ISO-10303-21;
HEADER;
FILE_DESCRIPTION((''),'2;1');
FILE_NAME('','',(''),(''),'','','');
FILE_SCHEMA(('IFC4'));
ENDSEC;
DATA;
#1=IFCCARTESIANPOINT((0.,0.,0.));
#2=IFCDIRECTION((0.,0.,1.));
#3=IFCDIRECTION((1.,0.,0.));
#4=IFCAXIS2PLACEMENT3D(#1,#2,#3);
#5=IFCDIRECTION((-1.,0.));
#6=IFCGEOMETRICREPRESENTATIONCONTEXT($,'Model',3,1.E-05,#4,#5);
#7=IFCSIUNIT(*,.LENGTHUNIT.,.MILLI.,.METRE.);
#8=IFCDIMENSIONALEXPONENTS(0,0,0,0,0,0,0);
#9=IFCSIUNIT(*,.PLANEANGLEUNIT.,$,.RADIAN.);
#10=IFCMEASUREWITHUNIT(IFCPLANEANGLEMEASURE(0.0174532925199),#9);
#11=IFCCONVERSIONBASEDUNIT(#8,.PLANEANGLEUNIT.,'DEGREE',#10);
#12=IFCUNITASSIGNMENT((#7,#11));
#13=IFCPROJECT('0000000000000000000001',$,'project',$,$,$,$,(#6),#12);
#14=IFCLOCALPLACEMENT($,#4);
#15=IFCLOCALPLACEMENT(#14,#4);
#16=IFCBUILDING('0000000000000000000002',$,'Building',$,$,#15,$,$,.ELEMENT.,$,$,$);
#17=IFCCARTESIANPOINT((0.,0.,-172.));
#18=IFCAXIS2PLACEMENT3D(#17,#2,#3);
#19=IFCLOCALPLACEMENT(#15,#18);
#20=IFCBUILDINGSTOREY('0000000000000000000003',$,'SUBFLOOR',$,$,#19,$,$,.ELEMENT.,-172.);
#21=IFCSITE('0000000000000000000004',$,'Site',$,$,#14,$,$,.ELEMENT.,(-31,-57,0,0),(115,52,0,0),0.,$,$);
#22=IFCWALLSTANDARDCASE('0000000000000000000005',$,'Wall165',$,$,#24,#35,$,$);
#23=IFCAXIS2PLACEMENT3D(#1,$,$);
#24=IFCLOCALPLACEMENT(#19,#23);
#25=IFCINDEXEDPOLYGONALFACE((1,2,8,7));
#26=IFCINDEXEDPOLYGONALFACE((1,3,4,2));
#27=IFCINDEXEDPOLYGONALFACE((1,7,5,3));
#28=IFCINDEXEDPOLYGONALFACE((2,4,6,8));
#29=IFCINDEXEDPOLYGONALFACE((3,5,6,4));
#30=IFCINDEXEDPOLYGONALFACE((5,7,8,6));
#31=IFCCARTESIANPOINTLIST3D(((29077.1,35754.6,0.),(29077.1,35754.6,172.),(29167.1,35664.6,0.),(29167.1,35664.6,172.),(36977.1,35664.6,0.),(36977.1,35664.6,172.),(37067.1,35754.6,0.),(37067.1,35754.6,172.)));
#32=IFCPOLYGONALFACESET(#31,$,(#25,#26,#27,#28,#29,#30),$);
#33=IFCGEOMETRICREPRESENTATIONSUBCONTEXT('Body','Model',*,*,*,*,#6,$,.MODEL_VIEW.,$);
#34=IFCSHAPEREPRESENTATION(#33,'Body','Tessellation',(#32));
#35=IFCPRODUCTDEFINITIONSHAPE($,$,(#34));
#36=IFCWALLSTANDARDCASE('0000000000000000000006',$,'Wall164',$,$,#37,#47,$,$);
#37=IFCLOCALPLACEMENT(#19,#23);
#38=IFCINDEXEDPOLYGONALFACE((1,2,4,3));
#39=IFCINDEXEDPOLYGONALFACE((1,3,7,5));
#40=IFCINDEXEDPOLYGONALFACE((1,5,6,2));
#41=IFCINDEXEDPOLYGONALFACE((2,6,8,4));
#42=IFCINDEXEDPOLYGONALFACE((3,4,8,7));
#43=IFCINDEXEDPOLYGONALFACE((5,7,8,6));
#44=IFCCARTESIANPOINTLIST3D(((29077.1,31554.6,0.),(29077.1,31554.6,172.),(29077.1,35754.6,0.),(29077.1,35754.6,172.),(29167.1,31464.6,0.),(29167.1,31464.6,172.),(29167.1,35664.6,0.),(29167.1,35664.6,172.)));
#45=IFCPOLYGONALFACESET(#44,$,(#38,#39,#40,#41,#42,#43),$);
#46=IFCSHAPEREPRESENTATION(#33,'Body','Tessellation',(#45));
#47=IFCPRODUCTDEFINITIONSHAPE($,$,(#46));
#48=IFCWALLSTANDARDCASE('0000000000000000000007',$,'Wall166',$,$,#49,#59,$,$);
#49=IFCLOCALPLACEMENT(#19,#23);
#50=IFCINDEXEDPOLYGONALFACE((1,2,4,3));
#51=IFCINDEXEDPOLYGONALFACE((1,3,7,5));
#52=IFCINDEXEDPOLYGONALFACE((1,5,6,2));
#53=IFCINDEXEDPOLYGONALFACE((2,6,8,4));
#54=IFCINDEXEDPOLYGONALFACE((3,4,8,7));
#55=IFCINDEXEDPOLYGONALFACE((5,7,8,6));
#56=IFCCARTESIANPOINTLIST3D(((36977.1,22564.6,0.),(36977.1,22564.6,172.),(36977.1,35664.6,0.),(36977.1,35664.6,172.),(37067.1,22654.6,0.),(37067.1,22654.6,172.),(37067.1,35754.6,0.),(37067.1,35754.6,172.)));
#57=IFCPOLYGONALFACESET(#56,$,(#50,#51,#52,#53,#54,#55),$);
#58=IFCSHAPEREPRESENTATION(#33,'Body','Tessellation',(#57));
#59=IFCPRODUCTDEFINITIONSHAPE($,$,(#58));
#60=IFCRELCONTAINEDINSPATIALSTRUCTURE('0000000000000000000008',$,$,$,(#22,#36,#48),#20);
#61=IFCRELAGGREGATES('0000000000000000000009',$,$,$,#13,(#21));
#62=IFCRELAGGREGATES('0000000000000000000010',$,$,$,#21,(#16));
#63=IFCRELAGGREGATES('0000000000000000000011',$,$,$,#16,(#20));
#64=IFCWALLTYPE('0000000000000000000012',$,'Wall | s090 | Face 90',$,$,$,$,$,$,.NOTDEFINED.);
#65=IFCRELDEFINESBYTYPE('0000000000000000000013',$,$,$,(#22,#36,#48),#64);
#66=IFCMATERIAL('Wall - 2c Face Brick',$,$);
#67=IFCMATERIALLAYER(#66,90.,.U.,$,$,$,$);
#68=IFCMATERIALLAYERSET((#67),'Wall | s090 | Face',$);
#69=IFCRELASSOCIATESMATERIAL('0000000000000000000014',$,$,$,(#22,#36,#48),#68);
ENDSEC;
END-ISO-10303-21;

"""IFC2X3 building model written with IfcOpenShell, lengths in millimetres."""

from ifc_helpers import new_model, entity, si_unit, converted_unit, direction, frame, origin_with_axes, place, context, subcontext, project, spatial, polyline, outline, extrude, material, layer, layer_set, layer_usage, type_object, element, save


model = new_model("IFC2X3")

# Units and contexts
model_context = context("Model", 3, precision=1e-05, world=origin_with_axes(), true_north=direction((-1.0, 0.0)))
body_context = subcontext(model_context, "Body", "Model", "MODEL_VIEW")
ifc_project = project(units=[si_unit("LENGTHUNIT", "METRE", prefix="MILLI"), converted_unit("PLANEANGLEUNIT", "DEGREE", entity("IfcPlaneAngleMeasure", 0.0174532925199), si_unit("PLANEANGLEUNIT", "RADIAN"), dimensions=[0, 0, 0, 0, 0, 0, 0])], contexts=[model_context])

# Site, building, storey
site_placement = place(None, origin_with_axes())
site = spatial("IfcSite", under=ifc_project, at=site_placement, Name="Site", CompositionType="ELEMENT", RefLatitude=(-31, -57, 0, 0), RefLongitude=(115, 52, 0, 0), RefElevation=0.0)
building_placement = place(site_placement, origin_with_axes())
building = spatial("IfcBuilding", under=site, at=building_placement, Name="Building", CompositionType="ELEMENT")
storey_placement = place(building_placement, frame((0.0, 0.0, -172.0), z_axis=(0.0, 0.0, 1.0), x_axis=(1.0, 0.0, 0.0)))
storey = spatial("IfcBuildingStorey", under=building, at=storey_placement, Name="SUBFLOOR", CompositionType="ELEMENT", Elevation=-172.0)

# Walls
ifc_material_1 = material(Name="Wall - 2c Face Brick")
ifc_layer_1 = layer(ifc_material_1, 90.0, ventilated="UNKNOWN")
ifc_layer_set_1 = layer_set([ifc_layer_1], Name="Wall | s090 | Face")
wall_type_1 = type_object("IfcWallType", Name="Wall | s090 | Face 90", PredefinedType="NOTDEFINED")
ifc_layer_usage_1 = layer_usage(ifc_layer_set_1, "AXIS2", "NEGATIVE", 0.0)
wall_1_placement = place(storey_placement, frame((29077.1, 35754.6, 0.0), z_axis=(0.0, 0.0, 1.0), x_axis=(1.0, 0.0, 0.0)))
element("IfcWallStandardCase", 1, at=wall_1_placement, inside=storey, type_object=wall_type_1, material=ifc_layer_usage_1, Name="Wall165", context=body_context, shape_type="SweptSolid", body=[
    extrude(outline(polyline([(90.0, -90.0), (7900.0, -90.0), (7990.0, 0.0), (0.0, 0.0), (90.0, -90.0)])), origin_with_axes(), (0.0, 0.0, 1.0), 172.0),
])
ifc_layer_usage_2 = layer_usage(ifc_layer_set_1, "AXIS2", "NEGATIVE", 0.0)
wall_2_placement = place(storey_placement, frame((29077.1, 31554.6, 0.0), z_axis=(0.0, 0.0, 1.0), x_axis=(0.0, 1.0, 0.0)))
element("IfcWallStandardCase", 2, at=wall_2_placement, inside=storey, type_object=wall_type_1, material=ifc_layer_usage_2, Name="Wall164", context=body_context, shape_type="SweptSolid", body=[
    extrude(outline(polyline([(-90.0, -90.0), (4110.0, -90.0), (4200.0, 0.0), (0.0, 0.0), (-90.0, -90.0)])), origin_with_axes(), (0.0, 0.0, 1.0), 172.0),
])
ifc_layer_usage_3 = layer_usage(ifc_layer_set_1, "AXIS2", "NEGATIVE", 0.0)
wall_3_placement = place(storey_placement, frame((37067.1, 35754.6, 0.0), z_axis=(0.0, 0.0, 1.0), x_axis=(0.0, -1.0, 0.0)))
element("IfcWallStandardCase", 3, at=wall_3_placement, inside=storey, type_object=wall_type_1, material=ifc_layer_usage_3, Name="Wall166", context=body_context, shape_type="SweptSolid", body=[
    extrude(outline(polyline([(90.0, -90.0), (13190.0, -90.0), (13100.0, 0.0), (0.0, 0.0), (90.0, -90.0)])), origin_with_axes(), (0.0, 0.0, 1.0), 172.0),
])

save(model, "model.ifc")
